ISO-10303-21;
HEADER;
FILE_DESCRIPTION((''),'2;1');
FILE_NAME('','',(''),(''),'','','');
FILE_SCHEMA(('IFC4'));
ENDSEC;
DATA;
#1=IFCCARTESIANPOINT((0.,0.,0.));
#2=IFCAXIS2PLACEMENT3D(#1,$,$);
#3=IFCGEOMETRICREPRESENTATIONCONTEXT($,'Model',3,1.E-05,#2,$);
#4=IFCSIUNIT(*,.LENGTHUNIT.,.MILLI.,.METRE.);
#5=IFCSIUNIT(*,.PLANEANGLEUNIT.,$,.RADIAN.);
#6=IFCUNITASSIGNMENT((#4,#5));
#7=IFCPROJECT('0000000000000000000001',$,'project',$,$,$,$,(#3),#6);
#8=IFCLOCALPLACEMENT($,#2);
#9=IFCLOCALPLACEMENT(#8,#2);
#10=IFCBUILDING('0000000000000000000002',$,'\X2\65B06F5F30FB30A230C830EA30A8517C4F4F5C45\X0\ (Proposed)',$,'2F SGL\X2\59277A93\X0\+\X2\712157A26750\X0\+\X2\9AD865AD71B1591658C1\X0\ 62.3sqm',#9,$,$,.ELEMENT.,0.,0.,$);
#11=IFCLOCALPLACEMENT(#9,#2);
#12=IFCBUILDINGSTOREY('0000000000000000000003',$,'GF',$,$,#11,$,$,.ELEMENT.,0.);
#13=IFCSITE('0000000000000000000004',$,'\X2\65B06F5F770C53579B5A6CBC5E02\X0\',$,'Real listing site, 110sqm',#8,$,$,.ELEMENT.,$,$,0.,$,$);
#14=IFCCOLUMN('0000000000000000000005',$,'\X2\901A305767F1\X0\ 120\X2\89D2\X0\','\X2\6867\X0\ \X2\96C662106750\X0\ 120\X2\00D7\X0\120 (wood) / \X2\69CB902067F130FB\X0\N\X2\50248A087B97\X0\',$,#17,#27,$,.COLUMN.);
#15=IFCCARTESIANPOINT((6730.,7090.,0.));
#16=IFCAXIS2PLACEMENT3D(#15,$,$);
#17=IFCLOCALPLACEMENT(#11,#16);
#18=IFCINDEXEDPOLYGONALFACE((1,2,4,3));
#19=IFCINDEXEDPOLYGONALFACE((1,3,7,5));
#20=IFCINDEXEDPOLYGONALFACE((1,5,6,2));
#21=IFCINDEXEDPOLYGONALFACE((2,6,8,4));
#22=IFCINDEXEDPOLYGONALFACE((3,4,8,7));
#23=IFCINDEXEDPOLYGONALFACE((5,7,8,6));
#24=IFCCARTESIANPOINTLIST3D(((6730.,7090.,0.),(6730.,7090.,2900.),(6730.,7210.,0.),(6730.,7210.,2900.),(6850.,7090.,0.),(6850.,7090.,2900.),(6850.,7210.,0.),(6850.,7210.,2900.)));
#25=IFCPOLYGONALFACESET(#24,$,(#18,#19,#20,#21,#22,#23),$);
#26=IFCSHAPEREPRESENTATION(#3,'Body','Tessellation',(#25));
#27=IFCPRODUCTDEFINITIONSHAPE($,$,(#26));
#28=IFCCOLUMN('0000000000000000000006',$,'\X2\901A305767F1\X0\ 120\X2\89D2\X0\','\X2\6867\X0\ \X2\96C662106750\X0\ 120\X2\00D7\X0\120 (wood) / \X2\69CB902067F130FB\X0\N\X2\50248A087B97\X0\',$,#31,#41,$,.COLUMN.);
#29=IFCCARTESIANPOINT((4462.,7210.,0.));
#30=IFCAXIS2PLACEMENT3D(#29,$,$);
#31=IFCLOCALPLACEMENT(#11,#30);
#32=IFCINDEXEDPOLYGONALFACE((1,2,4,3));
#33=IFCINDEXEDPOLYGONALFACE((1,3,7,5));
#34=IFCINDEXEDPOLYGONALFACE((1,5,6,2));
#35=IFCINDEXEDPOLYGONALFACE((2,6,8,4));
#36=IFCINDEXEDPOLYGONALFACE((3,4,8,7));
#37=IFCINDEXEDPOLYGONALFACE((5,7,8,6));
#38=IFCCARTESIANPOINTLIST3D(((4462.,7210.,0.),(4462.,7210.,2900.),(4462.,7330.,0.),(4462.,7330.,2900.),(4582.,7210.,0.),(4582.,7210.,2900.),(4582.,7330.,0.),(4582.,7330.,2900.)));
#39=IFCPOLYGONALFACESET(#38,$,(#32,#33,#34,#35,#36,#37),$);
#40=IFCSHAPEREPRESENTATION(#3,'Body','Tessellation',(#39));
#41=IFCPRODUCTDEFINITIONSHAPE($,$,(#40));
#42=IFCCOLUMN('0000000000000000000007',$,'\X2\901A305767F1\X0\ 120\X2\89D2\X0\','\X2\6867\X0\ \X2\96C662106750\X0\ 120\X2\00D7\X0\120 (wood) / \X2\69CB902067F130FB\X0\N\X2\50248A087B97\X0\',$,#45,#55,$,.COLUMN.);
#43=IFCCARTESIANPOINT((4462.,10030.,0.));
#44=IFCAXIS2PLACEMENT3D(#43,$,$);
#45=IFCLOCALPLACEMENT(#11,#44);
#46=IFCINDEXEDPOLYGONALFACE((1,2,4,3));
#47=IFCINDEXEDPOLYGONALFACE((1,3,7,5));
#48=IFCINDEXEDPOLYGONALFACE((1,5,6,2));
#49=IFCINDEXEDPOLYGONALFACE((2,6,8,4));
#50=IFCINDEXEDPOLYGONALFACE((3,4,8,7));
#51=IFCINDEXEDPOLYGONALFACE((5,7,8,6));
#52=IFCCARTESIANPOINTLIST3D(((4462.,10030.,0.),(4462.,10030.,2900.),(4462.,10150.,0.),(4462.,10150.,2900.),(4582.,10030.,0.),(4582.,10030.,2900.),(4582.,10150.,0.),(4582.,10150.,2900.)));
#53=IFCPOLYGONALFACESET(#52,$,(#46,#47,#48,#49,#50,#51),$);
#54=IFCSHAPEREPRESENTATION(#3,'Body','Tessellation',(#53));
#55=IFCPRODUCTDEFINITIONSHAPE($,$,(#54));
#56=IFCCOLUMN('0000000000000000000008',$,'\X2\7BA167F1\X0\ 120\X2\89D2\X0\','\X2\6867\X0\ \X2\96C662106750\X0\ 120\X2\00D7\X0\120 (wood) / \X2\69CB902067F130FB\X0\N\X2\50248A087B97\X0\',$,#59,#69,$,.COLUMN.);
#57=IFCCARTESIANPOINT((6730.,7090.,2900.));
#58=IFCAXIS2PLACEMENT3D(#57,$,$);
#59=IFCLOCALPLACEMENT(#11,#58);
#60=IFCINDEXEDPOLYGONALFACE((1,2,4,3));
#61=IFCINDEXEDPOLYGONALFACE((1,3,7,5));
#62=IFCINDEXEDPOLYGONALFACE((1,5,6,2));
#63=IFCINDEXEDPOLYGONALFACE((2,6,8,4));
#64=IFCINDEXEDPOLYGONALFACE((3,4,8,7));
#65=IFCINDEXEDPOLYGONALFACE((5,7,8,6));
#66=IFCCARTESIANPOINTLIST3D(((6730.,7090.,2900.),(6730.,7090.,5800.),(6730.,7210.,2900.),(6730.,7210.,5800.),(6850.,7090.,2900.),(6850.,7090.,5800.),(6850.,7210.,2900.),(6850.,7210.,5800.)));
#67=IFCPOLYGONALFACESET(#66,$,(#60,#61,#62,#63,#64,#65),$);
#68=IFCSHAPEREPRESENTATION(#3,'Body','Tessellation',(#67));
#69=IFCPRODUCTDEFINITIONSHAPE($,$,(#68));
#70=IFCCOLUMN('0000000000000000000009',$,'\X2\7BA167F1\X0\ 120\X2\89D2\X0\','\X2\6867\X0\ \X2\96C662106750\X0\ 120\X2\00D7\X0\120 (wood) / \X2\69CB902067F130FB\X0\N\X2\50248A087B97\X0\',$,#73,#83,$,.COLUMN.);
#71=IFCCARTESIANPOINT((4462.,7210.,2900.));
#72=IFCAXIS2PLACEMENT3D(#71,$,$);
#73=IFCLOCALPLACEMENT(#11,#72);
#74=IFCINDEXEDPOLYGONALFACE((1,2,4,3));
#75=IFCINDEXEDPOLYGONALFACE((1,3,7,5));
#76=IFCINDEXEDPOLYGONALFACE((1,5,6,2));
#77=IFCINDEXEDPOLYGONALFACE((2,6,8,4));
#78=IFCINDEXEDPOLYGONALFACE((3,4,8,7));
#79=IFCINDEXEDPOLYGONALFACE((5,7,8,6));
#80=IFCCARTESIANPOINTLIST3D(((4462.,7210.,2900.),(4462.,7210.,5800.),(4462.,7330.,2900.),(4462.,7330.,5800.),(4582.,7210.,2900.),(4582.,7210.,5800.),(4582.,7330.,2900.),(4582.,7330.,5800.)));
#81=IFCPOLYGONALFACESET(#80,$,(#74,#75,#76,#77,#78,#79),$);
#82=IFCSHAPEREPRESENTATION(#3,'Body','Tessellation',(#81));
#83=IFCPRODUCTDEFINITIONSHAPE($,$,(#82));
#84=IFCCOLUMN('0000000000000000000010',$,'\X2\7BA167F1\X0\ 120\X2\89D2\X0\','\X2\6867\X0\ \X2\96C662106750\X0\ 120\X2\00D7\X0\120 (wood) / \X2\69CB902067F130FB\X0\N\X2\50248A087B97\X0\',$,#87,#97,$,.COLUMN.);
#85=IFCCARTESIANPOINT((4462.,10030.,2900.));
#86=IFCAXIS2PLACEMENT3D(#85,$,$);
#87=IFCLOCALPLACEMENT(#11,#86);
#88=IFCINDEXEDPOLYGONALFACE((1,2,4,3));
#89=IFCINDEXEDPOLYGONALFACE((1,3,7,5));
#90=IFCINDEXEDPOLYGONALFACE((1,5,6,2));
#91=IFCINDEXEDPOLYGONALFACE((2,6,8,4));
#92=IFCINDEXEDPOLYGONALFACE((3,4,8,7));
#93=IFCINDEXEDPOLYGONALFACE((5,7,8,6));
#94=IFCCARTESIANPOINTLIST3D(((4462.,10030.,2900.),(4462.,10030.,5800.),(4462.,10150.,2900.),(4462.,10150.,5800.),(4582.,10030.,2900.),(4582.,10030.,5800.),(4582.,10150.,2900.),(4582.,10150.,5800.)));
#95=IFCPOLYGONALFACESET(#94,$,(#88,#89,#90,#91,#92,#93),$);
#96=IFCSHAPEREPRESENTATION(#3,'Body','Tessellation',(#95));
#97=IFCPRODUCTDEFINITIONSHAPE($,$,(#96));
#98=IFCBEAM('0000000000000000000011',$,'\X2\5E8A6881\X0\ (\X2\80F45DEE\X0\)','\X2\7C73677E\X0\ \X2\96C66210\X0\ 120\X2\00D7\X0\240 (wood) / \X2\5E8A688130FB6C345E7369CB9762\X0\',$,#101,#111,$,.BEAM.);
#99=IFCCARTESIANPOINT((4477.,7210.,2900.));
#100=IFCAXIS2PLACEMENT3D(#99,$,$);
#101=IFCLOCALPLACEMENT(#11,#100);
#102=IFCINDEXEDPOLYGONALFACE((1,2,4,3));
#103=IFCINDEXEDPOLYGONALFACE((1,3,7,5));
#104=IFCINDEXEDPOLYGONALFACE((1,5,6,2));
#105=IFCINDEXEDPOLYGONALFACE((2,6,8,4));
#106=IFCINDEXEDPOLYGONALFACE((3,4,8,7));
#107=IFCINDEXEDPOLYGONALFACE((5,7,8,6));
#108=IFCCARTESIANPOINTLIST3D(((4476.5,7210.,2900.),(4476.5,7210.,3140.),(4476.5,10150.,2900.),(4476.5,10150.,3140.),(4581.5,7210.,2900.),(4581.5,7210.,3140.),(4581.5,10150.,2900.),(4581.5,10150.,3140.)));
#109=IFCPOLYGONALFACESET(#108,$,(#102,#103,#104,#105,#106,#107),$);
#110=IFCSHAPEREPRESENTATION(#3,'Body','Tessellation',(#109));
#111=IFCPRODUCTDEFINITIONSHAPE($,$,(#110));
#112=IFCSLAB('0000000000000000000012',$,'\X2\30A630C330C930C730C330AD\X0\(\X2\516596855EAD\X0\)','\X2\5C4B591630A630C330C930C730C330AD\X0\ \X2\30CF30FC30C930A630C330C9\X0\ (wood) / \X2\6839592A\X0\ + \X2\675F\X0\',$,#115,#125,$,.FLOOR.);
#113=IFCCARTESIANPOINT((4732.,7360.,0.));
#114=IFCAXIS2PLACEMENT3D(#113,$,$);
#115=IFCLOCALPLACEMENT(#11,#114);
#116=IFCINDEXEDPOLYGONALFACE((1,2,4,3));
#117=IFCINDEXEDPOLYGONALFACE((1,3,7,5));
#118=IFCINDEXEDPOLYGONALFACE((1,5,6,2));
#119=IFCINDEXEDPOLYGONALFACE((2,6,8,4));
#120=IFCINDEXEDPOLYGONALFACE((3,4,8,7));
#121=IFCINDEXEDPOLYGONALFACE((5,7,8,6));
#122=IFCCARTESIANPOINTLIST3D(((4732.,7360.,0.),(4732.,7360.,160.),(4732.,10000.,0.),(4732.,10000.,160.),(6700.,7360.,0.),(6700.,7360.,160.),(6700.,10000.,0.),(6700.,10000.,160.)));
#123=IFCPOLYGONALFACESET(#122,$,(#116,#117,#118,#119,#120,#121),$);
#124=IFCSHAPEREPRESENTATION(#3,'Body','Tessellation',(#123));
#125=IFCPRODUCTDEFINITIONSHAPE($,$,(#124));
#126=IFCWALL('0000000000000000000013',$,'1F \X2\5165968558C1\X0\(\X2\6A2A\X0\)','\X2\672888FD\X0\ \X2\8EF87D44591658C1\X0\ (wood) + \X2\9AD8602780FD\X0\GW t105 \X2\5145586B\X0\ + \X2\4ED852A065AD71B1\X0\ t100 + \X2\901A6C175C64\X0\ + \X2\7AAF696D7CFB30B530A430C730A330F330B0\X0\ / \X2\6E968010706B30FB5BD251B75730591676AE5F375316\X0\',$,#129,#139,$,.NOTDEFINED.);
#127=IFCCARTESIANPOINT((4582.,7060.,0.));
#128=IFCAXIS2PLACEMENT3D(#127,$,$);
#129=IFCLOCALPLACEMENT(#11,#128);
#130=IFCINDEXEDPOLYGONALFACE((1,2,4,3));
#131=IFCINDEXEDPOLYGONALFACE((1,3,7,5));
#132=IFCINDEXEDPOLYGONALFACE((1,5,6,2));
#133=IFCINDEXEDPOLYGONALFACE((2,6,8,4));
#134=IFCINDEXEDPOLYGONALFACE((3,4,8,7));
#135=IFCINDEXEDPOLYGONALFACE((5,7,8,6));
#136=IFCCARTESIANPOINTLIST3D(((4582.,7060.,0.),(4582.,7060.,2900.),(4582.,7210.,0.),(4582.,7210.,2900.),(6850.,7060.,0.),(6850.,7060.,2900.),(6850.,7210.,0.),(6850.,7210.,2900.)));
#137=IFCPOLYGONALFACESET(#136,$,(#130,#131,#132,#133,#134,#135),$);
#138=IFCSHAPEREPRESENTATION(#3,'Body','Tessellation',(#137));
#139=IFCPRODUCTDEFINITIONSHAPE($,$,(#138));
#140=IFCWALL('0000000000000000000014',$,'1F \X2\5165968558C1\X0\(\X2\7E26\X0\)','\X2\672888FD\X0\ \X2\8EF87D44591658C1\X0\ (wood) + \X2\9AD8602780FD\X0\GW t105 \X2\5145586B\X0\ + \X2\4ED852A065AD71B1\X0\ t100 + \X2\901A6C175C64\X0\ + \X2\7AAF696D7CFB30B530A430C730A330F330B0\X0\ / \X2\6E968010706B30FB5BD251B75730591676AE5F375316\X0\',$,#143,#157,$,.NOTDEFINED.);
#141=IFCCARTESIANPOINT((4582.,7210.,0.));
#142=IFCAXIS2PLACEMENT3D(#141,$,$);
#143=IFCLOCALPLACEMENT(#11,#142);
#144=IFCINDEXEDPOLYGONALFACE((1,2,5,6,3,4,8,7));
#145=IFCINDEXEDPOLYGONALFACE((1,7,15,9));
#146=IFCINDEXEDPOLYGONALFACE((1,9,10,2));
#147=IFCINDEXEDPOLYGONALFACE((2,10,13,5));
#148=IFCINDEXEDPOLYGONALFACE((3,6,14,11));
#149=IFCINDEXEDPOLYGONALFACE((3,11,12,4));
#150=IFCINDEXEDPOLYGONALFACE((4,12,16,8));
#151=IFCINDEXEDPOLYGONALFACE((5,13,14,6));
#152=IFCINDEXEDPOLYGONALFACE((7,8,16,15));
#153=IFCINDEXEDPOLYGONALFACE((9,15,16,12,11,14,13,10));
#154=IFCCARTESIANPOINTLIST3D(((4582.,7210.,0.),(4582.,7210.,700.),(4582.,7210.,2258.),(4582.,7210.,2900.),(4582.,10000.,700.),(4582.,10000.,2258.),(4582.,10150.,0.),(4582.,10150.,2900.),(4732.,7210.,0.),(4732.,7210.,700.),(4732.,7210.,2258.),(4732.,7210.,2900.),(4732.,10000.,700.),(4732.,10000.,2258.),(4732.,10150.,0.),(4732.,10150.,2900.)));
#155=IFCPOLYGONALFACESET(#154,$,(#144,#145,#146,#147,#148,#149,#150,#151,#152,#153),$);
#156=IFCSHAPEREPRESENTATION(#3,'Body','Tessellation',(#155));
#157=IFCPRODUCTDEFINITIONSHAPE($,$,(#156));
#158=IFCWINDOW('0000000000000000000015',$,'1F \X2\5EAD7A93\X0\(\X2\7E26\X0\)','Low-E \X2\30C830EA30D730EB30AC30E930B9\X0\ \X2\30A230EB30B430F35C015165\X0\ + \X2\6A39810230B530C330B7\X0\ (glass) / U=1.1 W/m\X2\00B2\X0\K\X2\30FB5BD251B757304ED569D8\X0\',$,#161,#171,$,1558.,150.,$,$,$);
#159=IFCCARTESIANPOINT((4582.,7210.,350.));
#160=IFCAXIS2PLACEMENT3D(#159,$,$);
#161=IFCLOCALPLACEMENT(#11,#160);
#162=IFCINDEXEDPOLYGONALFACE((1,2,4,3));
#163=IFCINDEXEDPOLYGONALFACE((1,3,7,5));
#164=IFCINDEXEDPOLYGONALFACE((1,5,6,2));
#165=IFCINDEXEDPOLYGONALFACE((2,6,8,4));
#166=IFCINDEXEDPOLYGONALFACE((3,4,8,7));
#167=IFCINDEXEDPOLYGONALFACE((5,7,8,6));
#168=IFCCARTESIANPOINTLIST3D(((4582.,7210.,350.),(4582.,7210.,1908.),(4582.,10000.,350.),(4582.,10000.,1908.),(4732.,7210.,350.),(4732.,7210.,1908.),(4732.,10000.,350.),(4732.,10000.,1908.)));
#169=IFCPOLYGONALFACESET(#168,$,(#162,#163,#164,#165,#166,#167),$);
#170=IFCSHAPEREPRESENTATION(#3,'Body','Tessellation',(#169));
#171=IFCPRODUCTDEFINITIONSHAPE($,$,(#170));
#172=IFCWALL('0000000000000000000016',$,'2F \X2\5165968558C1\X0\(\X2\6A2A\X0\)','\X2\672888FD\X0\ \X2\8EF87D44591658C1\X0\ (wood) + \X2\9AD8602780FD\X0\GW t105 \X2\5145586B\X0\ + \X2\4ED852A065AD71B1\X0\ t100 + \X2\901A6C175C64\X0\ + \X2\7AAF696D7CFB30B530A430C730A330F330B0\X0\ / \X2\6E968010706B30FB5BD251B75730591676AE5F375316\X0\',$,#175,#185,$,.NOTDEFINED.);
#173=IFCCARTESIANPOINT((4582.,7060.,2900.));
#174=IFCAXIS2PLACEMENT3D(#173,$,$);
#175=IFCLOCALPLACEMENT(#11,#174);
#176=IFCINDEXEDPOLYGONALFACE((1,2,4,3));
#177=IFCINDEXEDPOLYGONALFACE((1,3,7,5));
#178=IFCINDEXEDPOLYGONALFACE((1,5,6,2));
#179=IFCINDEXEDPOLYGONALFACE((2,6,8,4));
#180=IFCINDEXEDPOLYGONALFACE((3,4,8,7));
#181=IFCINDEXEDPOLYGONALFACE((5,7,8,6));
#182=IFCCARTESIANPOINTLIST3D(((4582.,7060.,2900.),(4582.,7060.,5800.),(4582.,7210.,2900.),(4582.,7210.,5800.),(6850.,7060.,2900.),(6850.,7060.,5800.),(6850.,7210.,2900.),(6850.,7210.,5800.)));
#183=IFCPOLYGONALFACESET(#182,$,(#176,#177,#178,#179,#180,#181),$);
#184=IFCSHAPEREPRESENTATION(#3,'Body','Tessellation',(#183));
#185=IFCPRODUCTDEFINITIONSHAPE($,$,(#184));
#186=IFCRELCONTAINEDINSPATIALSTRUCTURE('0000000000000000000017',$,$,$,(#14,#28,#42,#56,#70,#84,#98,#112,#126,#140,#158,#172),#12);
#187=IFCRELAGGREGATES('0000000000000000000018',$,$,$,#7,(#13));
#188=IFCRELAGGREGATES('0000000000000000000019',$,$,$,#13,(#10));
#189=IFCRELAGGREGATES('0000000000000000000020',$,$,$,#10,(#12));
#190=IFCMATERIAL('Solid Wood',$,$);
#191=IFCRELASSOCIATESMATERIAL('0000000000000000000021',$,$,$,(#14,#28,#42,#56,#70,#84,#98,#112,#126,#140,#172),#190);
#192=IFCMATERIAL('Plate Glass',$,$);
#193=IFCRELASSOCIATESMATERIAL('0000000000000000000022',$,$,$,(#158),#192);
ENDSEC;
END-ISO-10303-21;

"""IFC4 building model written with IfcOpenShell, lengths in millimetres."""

from ifc_helpers import new_model, si_unit, frame, frame_2d, origin, place, context, project, spatial, rectangle, extrude, material, element, fill, save


model = new_model("IFC4")

# Units and contexts
model_context = context("Model", 3, precision=1e-05, world=origin())
ifc_project = project(units=[si_unit("LENGTHUNIT", "METRE", prefix="MILLI"), si_unit("PLANEANGLEUNIT", "RADIAN")], contexts=[model_context])

# Site, building, storey
site_placement = place(None, origin())
site = spatial("IfcSite", under=ifc_project, at=site_placement, Name="新潟県南魚沼市", ObjectType="Real listing site, 110sqm", CompositionType="ELEMENT", RefElevation=0.0)
building_placement = place(site_placement, origin())
building = spatial("IfcBuilding", under=site, at=building_placement, Name="新潟・アトリエ兼住居 (Proposed)", ObjectType="2F SGL大窓+無垢材+高断熱外壁 62.3sqm", CompositionType="ELEMENT", ElevationOfRefHeight=0.0, ElevationOfTerrain=0.0)
storey_placement = place(building_placement, origin())
storey = spatial("IfcBuildingStorey", under=building, at=storey_placement, Name="GF", CompositionType="ELEMENT", Elevation=0.0)

# Columns
ifc_material_1 = material(Name="Solid Wood")
column_1_placement = place(storey_placement, frame((6730.0, 7090.0, 0.0)))
element("IfcColumn", 1, at=column_1_placement, inside=storey, material=ifc_material_1, Name="通し柱 120角", Description="桧 集成材 120×120 (wood) / 構造柱・N値計算", PredefinedType="COLUMN", context=model_context, shape_type="SweptSolid", body=[
    extrude(rectangle(XDim=120.0, YDim=120.0, at=frame_2d((60.0, 60.0))), frame((6730.0, 7090.0, 0.0)), (0.0, 0.0, 1.0), 2900.0),
])
column_2_placement = place(storey_placement, frame((4462.0, 7210.0, 0.0)))
element("IfcColumn", 2, at=column_2_placement, inside=storey, material=ifc_material_1, Name="通し柱 120角", Description="桧 集成材 120×120 (wood) / 構造柱・N値計算", PredefinedType="COLUMN", context=model_context, shape_type="SweptSolid", body=[
    extrude(rectangle(XDim=120.0, YDim=120.0, at=frame_2d((60.0, 60.0))), frame((4462.0, 7210.0, 0.0)), (0.0, 0.0, 1.0), 2900.0),
])
column_3_placement = place(storey_placement, frame((4462.0, 10030.0, 0.0)))
element("IfcColumn", 3, at=column_3_placement, inside=storey, material=ifc_material_1, Name="通し柱 120角", Description="桧 集成材 120×120 (wood) / 構造柱・N値計算", PredefinedType="COLUMN", context=model_context, shape_type="SweptSolid", body=[
    extrude(rectangle(XDim=120.0, YDim=120.0, at=frame_2d((60.0, 60.0))), frame((4462.0, 10030.0, 0.0)), (0.0, 0.0, 1.0), 2900.0),
])
column_4_placement = place(storey_placement, frame((6730.0, 7090.0, 2900.0)))
element("IfcColumn", 4, at=column_4_placement, inside=storey, material=ifc_material_1, Name="管柱 120角", Description="桧 集成材 120×120 (wood) / 構造柱・N値計算", PredefinedType="COLUMN", context=model_context, shape_type="SweptSolid", body=[
    extrude(rectangle(XDim=120.0, YDim=120.0, at=frame_2d((60.0, 60.0))), frame((6730.0, 7090.0, 2900.0)), (0.0, 0.0, 1.0), 2900.0),
])
column_5_placement = place(storey_placement, frame((4462.0, 7210.0, 2900.0)))
element("IfcColumn", 5, at=column_5_placement, inside=storey, material=ifc_material_1, Name="管柱 120角", Description="桧 集成材 120×120 (wood) / 構造柱・N値計算", PredefinedType="COLUMN", context=model_context, shape_type="SweptSolid", body=[
    extrude(rectangle(XDim=120.0, YDim=120.0, at=frame_2d((60.0, 60.0))), frame((4462.0, 7210.0, 2900.0)), (0.0, 0.0, 1.0), 2900.0),
])
column_6_placement = place(storey_placement, frame((4462.0, 10030.0, 2900.0)))
element("IfcColumn", 6, at=column_6_placement, inside=storey, material=ifc_material_1, Name="管柱 120角", Description="桧 集成材 120×120 (wood) / 構造柱・N値計算", PredefinedType="COLUMN", context=model_context, shape_type="SweptSolid", body=[
    extrude(rectangle(XDim=120.0, YDim=120.0, at=frame_2d((60.0, 60.0))), frame((4462.0, 10030.0, 2900.0)), (0.0, 0.0, 1.0), 2900.0),
])

# Beam
beam_1_placement = place(storey_placement, frame((4477.0, 7210.0, 2900.0)))
element("IfcBeam", 7, at=beam_1_placement, inside=storey, material=ifc_material_1, Name="床梁 (胴差)", Description="米松 集成 120×240 (wood) / 床梁・水平構面", PredefinedType="BEAM", context=model_context, shape_type="SweptSolid", body=[
    extrude(rectangle(XDim=105.0, YDim=2940.0, at=frame_2d((52.0, 1470.0))), frame((4477.0, 7210.0, 2900.0)), (0.0, 0.0, 1.0), 240.0),
])

# Slab
slab_placement = place(storey_placement, frame((4732.0, 7360.0, 0.0)))
element("IfcSlab", 8, at=slab_placement, inside=storey, material=ifc_material_1, Name="ウッドデッキ(入隅庭)", Description="屋外ウッドデッキ ハードウッド (wood) / 根太 + 束", PredefinedType="FLOOR", context=model_context, shape_type="SweptSolid", body=[
    extrude(rectangle(XDim=1968.0, YDim=2640.0, at=frame_2d((984.0, 1320.0))), frame((4732.0, 7360.0, 0.0)), (0.0, 0.0, 1.0), 160.0),
])

# Wall
wall_1_placement = place(storey_placement, frame((4582.0, 7060.0, 0.0)))
element("IfcWall", 9, at=wall_1_placement, inside=storey, material=ifc_material_1, Name="1F 入隅壁(横)", Description="木製 軸組外壁 (wood) + 高性能GW t105 充填 + 付加断熱 t100 + 通気層 + 窯業系サイディング / 準耐火・寒冷地外皮強化", PredefinedType="NOTDEFINED", context=model_context, shape_type="SweptSolid", body=[
    extrude(rectangle(XDim=2268.0, YDim=150.0, at=frame_2d((1134.0, 75.0))), frame((4582.0, 7060.0, 0.0)), (0.0, 0.0, 1.0), 2900.0),
])

# Wall, opening, window
wall_2_placement = place(storey_placement, frame((4582.0, 7210.0, 0.0)))
wall_2 = element("IfcWall", 10, at=wall_2_placement, inside=storey, material=ifc_material_1, Name="1F 入隅壁(縦)", Description="木製 軸組外壁 (wood) + 高性能GW t105 充填 + 付加断熱 t100 + 通気層 + 窯業系サイディング / 準耐火・寒冷地外皮強化", PredefinedType="NOTDEFINED", context=model_context, shape_type="SweptSolid", body=[
    extrude(rectangle(XDim=150.0, YDim=2940.0, at=frame_2d((75.0, 1470.0))), frame((4582.0, 7210.0, 0.0)), (0.0, 0.0, 1.0), 2900.0),
])
opening_1_placement = place(storey_placement, frame((4582.0, 7210.0, 350.0)))
opening_1 = element("IfcOpeningElement", 11, at=opening_1_placement, cuts=wall_2, PredefinedType="NOTDEFINED", context=model_context, shape_type="SweptSolid", body=[
    extrude(rectangle(XDim=150.0, YDim=2790.0, at=frame_2d((75.0, 1395.0))), frame((4582.0, 7210.0, 350.0)), (0.0, 0.0, 1.0), 1558.0),
])
ifc_material_2 = material(Name="Plate Glass")
window_1_placement = place(storey_placement, frame((4582.0, 7210.0, 350.0)))
window_1 = element("IfcWindow", 12, at=window_1_placement, inside=storey, material=ifc_material_2, Name="1F 庭窓(縦)", Description="Low-E トリプルガラス アルゴン封入 + 樹脂サッシ (glass) / U=1.1 W/m²K・寒冷地仕様", OverallHeight=1558.0, OverallWidth=150.0, context=model_context, shape_type="SweptSolid", body=[
    extrude(rectangle(XDim=150.0, YDim=2790.0, at=frame_2d((75.0, 1395.0))), frame((4582.0, 7210.0, 350.0)), (0.0, 0.0, 1.0), 1558.0),
])
fill(opening_1, window_1)

# Wall
wall_3_placement = place(storey_placement, frame((4582.0, 7060.0, 2900.0)))
element("IfcWall", 13, at=wall_3_placement, inside=storey, material=ifc_material_1, Name="2F 入隅壁(横)", Description="木製 軸組外壁 (wood) + 高性能GW t105 充填 + 付加断熱 t100 + 通気層 + 窯業系サイディング / 準耐火・寒冷地外皮強化", PredefinedType="NOTDEFINED", context=model_context, shape_type="SweptSolid", body=[
    extrude(rectangle(XDim=2268.0, YDim=150.0, at=frame_2d((1134.0, 75.0))), frame((4582.0, 7060.0, 2900.0)), (0.0, 0.0, 1.0), 2900.0),
])

save(model, "model.ifc")
